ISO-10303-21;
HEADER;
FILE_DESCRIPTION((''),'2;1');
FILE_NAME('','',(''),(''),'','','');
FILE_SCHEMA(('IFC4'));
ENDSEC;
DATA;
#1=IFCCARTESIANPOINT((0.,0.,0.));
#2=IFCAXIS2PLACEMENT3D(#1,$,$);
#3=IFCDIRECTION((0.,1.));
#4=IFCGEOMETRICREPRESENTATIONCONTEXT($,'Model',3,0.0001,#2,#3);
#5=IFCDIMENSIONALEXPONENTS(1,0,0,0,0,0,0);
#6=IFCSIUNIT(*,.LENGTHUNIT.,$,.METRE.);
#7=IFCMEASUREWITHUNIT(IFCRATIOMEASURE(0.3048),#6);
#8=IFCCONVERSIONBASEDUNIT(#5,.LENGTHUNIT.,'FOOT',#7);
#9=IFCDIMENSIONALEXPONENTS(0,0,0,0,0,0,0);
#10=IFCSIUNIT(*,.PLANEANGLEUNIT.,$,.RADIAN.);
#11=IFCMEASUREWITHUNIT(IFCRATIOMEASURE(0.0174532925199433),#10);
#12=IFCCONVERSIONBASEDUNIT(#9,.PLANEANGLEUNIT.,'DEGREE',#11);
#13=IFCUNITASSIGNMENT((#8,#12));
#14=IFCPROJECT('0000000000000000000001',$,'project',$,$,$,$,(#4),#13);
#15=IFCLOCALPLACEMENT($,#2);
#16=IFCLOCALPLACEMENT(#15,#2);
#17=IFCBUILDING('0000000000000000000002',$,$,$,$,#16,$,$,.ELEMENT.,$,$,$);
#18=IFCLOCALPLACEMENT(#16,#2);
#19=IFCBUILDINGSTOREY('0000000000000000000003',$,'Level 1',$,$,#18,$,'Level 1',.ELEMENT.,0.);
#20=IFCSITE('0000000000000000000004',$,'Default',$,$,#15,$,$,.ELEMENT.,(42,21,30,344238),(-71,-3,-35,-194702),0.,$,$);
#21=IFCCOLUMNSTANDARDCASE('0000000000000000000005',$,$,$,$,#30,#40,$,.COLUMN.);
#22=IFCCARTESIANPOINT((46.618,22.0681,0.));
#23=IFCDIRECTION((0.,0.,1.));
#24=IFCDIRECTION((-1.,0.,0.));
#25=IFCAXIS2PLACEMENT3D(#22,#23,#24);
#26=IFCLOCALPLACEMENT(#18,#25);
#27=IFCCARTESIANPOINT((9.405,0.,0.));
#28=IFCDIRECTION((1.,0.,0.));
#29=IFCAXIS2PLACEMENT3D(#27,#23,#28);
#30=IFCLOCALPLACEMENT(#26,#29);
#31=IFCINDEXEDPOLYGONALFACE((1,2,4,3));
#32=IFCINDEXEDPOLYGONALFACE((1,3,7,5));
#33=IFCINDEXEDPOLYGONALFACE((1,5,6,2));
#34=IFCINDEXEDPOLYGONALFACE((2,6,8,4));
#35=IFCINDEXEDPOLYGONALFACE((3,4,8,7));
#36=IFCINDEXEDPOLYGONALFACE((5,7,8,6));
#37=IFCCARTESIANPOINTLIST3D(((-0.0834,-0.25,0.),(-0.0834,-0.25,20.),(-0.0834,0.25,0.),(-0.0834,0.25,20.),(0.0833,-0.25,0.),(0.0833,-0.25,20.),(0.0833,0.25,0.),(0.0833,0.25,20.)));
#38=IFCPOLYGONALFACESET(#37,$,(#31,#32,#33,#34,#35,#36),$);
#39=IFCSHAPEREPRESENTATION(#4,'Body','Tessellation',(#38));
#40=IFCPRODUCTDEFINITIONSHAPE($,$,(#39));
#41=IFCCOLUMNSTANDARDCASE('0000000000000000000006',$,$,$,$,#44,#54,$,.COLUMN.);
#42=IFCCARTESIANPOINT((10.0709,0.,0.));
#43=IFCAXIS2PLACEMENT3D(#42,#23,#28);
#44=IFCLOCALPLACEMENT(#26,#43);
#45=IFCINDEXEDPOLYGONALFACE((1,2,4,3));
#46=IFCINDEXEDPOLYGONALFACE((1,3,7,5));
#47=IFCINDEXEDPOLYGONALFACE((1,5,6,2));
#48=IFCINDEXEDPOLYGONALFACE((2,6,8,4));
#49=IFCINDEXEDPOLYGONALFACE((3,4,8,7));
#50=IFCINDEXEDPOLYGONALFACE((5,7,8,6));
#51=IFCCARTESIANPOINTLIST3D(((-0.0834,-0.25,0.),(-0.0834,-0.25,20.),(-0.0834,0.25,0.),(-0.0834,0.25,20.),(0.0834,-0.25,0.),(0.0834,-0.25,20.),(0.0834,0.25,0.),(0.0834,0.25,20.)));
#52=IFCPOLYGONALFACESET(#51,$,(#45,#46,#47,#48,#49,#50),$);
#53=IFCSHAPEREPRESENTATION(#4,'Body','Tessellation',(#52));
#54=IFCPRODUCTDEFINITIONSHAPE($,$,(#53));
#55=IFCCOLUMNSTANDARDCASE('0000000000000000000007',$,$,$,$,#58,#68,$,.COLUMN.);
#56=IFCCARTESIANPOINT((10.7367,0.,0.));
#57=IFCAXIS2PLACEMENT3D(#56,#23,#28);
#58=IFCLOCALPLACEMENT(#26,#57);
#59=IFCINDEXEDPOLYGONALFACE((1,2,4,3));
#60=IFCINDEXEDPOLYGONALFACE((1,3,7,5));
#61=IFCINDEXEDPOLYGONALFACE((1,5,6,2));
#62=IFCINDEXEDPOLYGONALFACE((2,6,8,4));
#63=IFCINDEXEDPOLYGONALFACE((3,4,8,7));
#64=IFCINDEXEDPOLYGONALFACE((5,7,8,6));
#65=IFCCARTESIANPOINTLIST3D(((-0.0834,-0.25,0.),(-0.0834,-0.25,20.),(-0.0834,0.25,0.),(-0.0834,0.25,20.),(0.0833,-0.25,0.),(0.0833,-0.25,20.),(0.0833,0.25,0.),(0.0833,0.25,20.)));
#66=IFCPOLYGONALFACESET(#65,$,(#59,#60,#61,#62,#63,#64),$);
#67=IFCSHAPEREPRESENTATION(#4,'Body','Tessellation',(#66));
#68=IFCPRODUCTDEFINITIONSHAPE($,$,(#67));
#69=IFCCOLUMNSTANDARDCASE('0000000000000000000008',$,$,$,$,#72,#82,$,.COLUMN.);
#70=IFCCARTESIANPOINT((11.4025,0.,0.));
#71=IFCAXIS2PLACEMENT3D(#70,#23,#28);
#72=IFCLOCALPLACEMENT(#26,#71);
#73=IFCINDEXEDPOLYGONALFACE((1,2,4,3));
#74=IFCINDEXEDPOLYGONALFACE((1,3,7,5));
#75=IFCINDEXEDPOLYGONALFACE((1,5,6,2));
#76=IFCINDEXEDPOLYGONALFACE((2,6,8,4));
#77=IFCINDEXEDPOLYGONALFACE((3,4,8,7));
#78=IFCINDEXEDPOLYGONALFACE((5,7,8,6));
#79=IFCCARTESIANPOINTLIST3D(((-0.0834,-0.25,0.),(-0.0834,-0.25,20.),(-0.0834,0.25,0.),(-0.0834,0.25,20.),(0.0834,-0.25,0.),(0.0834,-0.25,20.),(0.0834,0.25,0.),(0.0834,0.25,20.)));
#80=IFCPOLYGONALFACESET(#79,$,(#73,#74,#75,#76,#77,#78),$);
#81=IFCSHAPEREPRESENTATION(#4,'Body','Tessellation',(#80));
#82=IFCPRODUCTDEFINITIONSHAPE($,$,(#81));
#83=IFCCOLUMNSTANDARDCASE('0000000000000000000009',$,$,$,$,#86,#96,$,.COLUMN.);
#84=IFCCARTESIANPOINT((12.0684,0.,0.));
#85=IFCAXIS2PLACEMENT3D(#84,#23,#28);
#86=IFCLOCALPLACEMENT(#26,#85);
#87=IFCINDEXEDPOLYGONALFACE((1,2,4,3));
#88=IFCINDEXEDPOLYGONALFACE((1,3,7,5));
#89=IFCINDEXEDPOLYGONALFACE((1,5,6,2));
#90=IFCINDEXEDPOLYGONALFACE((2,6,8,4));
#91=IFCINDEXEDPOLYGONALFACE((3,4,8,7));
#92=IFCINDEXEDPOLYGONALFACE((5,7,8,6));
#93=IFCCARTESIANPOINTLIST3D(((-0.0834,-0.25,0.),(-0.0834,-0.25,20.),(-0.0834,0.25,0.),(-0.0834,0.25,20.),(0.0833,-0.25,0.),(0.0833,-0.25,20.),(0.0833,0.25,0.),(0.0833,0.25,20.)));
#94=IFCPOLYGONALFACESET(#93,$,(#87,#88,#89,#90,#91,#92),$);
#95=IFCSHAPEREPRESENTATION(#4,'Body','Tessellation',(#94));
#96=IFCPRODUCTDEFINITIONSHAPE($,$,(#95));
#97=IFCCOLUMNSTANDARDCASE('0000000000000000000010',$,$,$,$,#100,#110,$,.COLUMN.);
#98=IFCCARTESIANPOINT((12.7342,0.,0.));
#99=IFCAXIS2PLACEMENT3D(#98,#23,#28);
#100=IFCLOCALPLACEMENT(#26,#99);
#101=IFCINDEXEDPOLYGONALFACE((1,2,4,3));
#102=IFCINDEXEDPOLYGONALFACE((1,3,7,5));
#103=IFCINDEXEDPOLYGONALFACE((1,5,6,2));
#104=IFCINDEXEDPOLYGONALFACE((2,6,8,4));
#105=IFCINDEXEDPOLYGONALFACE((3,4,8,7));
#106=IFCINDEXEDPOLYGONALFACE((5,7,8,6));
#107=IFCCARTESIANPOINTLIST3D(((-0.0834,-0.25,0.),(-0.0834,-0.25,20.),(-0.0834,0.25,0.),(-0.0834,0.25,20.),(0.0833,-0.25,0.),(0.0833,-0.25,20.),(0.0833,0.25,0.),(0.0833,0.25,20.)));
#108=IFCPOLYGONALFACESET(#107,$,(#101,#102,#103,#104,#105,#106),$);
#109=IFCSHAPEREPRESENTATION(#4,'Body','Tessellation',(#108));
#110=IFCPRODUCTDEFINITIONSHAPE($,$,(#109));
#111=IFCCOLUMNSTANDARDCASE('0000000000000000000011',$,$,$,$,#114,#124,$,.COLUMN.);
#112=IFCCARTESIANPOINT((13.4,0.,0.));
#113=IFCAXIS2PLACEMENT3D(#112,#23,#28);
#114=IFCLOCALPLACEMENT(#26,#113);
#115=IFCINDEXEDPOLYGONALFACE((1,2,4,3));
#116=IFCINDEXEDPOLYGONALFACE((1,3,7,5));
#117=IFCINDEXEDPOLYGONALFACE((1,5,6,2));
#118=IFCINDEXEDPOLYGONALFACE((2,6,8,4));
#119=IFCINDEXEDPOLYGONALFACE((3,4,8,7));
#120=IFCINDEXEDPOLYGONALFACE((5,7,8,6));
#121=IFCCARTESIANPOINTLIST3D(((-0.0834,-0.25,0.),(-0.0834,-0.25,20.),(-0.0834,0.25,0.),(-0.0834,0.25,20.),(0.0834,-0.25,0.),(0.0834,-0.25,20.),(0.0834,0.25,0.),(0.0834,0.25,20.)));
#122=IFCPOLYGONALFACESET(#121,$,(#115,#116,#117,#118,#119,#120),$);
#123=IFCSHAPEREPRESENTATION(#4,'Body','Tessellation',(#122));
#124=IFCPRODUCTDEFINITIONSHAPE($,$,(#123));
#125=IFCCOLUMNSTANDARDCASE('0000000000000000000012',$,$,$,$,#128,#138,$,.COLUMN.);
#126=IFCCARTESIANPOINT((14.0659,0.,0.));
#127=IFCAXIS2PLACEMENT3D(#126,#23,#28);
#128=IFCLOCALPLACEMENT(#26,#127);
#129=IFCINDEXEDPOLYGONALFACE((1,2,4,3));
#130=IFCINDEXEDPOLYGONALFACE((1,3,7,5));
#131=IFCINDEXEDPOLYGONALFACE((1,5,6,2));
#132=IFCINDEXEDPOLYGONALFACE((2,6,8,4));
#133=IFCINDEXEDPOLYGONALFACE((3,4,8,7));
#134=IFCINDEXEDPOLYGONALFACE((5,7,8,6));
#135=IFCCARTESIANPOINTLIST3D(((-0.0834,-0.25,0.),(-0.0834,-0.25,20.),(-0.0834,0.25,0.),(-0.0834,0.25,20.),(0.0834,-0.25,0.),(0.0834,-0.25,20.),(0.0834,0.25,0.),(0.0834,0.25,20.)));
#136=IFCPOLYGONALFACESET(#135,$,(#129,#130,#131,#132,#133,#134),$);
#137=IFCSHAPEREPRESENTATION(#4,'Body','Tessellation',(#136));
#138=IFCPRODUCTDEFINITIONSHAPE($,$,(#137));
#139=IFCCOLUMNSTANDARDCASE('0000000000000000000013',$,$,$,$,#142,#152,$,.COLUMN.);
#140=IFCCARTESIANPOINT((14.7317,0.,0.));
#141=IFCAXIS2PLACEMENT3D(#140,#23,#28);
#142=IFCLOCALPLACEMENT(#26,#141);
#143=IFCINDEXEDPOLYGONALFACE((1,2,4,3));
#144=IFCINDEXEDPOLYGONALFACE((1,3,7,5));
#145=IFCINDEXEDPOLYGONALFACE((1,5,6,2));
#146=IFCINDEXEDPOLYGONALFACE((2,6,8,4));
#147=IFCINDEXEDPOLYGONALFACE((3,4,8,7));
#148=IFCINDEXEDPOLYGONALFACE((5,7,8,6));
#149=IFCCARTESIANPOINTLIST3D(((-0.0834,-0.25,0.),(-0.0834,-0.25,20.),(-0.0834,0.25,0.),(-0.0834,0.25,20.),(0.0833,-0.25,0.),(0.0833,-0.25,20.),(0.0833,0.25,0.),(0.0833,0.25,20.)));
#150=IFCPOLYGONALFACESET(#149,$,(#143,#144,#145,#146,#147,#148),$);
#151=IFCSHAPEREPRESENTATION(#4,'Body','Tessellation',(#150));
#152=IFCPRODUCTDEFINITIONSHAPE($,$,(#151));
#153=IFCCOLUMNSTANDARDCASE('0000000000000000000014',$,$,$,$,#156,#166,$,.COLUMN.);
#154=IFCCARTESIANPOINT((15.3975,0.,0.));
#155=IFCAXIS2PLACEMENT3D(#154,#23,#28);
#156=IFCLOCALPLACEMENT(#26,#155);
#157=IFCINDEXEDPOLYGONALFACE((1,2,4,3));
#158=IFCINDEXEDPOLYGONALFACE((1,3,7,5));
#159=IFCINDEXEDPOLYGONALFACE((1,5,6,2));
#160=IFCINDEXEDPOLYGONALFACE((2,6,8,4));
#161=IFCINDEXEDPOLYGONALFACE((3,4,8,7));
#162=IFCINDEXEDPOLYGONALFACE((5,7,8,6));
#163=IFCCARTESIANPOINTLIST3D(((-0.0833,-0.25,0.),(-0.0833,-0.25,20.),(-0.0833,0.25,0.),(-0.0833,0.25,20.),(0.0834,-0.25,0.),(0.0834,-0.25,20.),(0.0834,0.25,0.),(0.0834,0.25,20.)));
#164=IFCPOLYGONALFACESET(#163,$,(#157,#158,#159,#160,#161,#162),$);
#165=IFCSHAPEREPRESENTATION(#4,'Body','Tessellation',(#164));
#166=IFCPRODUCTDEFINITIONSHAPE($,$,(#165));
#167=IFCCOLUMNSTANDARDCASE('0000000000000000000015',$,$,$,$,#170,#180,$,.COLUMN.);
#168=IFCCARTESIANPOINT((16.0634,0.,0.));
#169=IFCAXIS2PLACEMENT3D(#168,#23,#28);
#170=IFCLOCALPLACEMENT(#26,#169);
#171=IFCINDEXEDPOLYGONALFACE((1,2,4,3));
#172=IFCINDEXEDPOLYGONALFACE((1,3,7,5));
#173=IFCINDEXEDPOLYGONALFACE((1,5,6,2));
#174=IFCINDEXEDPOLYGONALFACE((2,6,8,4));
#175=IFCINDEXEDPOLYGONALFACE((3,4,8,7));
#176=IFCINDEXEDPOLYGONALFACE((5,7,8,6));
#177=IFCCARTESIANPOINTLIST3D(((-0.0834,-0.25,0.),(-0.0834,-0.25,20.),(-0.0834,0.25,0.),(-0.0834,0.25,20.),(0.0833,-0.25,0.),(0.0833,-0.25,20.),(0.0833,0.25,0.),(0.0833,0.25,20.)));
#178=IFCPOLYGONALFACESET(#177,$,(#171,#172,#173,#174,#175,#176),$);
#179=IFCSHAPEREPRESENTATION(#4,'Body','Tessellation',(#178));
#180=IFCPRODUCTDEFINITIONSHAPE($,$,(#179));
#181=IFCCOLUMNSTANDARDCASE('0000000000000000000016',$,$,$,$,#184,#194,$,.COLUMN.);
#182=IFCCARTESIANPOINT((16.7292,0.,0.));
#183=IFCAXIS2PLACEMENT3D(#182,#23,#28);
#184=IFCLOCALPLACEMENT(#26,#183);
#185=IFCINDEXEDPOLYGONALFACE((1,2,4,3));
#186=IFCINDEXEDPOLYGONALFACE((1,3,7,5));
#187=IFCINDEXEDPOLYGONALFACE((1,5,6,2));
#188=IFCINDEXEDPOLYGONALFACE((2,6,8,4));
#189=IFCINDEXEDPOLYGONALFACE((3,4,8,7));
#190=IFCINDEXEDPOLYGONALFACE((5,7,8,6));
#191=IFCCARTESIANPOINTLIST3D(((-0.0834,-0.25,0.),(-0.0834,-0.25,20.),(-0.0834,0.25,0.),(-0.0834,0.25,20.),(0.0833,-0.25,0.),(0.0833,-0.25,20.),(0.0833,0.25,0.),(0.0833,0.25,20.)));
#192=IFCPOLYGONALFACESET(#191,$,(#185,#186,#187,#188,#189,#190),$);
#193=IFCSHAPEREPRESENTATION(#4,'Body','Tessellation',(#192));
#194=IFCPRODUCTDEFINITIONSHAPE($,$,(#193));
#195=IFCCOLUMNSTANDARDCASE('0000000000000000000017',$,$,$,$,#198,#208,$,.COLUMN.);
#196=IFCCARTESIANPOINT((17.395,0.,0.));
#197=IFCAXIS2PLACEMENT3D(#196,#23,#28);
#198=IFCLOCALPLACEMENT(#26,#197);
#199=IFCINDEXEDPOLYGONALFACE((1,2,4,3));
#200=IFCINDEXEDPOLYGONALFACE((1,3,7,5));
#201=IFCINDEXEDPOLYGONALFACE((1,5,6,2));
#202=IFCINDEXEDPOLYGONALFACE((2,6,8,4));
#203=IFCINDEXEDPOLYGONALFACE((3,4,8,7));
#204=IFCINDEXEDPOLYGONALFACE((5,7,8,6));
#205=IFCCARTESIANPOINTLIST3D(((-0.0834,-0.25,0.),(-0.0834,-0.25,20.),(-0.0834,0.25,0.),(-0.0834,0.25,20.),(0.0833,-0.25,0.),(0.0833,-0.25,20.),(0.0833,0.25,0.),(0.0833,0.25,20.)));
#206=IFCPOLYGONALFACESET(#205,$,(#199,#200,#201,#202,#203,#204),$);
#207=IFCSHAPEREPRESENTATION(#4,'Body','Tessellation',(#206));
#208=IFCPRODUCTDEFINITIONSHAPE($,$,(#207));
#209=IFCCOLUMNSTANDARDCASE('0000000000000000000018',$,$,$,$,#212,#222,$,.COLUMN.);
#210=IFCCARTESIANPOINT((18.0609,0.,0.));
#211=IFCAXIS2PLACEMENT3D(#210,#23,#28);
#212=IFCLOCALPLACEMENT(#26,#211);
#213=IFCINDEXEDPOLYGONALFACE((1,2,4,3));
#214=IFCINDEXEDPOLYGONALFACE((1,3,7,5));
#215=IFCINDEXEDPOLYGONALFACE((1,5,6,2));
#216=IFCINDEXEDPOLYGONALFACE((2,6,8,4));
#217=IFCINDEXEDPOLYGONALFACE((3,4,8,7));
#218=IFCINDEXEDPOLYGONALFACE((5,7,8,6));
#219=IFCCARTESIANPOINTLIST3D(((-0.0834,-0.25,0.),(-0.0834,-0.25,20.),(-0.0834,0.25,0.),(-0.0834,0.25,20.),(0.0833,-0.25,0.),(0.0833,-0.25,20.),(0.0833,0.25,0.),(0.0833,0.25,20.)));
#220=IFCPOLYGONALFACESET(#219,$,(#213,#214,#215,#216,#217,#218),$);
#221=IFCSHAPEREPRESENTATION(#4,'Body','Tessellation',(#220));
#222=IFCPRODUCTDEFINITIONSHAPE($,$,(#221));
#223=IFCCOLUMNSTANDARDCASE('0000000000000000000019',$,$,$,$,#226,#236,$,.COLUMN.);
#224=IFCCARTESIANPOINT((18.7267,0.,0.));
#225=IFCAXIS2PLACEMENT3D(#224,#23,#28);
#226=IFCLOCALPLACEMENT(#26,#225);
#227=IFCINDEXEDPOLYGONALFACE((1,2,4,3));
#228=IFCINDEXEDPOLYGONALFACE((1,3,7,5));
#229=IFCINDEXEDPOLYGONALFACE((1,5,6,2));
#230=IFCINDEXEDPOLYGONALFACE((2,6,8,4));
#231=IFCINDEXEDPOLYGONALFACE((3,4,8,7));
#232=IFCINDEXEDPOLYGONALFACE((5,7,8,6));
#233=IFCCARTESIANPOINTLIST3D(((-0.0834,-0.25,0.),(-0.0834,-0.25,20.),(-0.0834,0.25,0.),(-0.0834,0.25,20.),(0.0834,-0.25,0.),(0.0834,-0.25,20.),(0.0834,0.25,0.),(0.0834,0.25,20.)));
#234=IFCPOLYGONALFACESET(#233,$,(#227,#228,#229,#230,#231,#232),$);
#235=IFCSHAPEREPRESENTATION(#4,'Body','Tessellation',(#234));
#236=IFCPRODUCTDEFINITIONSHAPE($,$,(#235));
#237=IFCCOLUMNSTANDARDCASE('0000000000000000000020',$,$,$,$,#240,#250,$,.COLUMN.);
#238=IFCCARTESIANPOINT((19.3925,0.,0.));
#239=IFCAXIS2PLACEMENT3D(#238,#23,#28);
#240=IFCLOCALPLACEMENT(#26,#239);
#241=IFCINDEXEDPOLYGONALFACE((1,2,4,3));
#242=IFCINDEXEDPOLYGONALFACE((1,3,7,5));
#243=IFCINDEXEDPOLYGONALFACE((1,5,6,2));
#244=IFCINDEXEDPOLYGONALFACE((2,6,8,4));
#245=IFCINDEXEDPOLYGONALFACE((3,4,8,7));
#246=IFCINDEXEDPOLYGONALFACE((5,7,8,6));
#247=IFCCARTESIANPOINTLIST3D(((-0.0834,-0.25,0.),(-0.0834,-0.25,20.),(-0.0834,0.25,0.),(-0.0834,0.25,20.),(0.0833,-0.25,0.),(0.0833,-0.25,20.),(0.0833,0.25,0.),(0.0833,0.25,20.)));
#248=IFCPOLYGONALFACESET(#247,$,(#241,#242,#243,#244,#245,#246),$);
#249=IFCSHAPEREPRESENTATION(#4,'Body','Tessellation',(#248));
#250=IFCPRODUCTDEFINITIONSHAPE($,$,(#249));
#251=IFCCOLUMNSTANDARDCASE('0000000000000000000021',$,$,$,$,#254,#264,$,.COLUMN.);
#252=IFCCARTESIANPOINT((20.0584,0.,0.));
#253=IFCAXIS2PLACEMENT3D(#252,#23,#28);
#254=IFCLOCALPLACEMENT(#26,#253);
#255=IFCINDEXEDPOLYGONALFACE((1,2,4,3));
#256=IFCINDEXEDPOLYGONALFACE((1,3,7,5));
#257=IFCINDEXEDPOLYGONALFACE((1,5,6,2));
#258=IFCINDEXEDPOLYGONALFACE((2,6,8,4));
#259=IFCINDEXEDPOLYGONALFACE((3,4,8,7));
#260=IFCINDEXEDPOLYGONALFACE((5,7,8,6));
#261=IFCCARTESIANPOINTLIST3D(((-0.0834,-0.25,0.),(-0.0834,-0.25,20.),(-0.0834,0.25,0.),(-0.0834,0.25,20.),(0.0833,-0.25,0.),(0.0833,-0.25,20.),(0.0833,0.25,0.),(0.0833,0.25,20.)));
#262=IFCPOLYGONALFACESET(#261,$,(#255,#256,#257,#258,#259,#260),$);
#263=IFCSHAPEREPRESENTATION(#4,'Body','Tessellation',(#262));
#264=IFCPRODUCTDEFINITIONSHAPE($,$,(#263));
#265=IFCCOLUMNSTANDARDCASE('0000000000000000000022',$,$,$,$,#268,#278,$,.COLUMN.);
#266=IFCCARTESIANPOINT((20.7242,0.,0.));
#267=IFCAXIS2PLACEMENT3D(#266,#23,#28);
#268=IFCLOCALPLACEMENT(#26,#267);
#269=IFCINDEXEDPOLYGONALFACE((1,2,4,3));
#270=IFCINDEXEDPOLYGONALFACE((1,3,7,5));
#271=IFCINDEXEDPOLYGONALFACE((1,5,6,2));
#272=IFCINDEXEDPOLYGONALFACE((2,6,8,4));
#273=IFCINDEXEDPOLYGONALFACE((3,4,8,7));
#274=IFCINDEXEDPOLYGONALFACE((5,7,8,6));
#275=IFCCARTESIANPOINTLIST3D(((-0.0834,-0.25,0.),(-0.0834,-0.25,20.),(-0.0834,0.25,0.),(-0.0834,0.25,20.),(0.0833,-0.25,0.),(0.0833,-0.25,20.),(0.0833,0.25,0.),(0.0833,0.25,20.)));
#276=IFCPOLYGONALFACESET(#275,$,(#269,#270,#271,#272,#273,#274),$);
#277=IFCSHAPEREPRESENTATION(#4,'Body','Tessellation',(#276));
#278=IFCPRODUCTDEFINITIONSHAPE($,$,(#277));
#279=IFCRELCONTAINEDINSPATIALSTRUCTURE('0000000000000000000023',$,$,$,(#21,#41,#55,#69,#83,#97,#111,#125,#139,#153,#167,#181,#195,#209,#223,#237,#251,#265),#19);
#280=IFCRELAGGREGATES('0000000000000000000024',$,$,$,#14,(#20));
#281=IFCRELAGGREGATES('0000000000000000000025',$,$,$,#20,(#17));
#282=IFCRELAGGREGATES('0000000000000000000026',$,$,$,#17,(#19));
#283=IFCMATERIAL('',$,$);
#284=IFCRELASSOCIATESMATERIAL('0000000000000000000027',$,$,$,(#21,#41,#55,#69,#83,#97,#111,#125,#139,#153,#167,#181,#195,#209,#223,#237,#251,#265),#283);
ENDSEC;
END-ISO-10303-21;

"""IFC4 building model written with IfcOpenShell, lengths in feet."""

from ifc_helpers import new_model, entity, si_unit, converted_unit, direction, frame, origin, place, context, project, spatial, rectangle, extrude, material, element, save


model = new_model("IFC4")

# Units and contexts
model_context = context("Model", 3, precision=0.0001, world=origin(), true_north=direction((0.0, 1.0)))
ifc_project = project(units=[converted_unit("LENGTHUNIT", "FOOT", entity("IfcRatioMeasure", 0.3048), si_unit("LENGTHUNIT", "METRE"), dimensions=[1, 0, 0, 0, 0, 0, 0]), converted_unit("PLANEANGLEUNIT", "DEGREE", entity("IfcRatioMeasure", 0.0174532925199433), si_unit("PLANEANGLEUNIT", "RADIAN"), dimensions=[0, 0, 0, 0, 0, 0, 0])], contexts=[model_context])

# Site, building, storey
site_placement = place(None, origin())
site = spatial("IfcSite", under=ifc_project, at=site_placement, Name="Default", CompositionType="ELEMENT", RefLatitude=(42, 21, 30, 344238), RefLongitude=(-71, -3, -35, -194702), RefElevation=0.0)
building_placement = place(site_placement, origin())
building = spatial("IfcBuilding", under=site, at=building_placement, CompositionType="ELEMENT")
storey_placement = place(building_placement, origin())
storey = spatial("IfcBuildingStorey", under=building, at=storey_placement, Name="Level 1", LongName="Level 1", CompositionType="ELEMENT", Elevation=0.0)

# Columns
ifc_material = material(Name="")
placement = place(storey_placement, frame((46.618, 22.0681, 0.0), z_axis=(0.0, 0.0, 1.0), x_axis=(-1.0, 0.0, 0.0)))
for number, where, z_axis, x_axis in (
    (1, (9.405, 0.0, 0.0), (0.0, 0.0, 1.0), (1.0, 0.0, 0.0)),
    (2, (10.0709, 0.0, 0.0), (0.0, 0.0, 1.0), (1.0, 0.0, 0.0)),
    (3, (10.7367, 0.0, 0.0), (0.0, 0.0, 1.0), (1.0, 0.0, 0.0)),
    (4, (11.4025, 0.0, 0.0), (0.0, 0.0, 1.0), (1.0, 0.0, 0.0)),
    (5, (12.0684, 0.0, 0.0), (0.0, 0.0, 1.0), (1.0, 0.0, 0.0)),
    (6, (12.7342, 0.0, 0.0), (0.0, 0.0, 1.0), (1.0, 0.0, 0.0)),
    (7, (13.4, 0.0, 0.0), (0.0, 0.0, 1.0), (1.0, 0.0, 0.0)),
    (8, (14.0659, 0.0, 0.0), (0.0, 0.0, 1.0), (1.0, 0.0, 0.0)),
    (9, (14.7317, 0.0, 0.0), (0.0, 0.0, 1.0), (1.0, 0.0, 0.0)),
    (10, (15.3975, 0.0, 0.0), (0.0, 0.0, 1.0), (1.0, 0.0, 0.0)),
    (11, (16.0634, 0.0, 0.0), (0.0, 0.0, 1.0), (1.0, 0.0, 0.0)),
    (12, (16.7292, 0.0, 0.0), (0.0, 0.0, 1.0), (1.0, 0.0, 0.0)),
    (13, (17.395, 0.0, 0.0), (0.0, 0.0, 1.0), (1.0, 0.0, 0.0)),
    (14, (18.0609, 0.0, 0.0), (0.0, 0.0, 1.0), (1.0, 0.0, 0.0)),
    (15, (18.7267, 0.0, 0.0), (0.0, 0.0, 1.0), (1.0, 0.0, 0.0)),
    (16, (19.3925, 0.0, 0.0), (0.0, 0.0, 1.0), (1.0, 0.0, 0.0)),
    (17, (20.0584, 0.0, 0.0), (0.0, 0.0, 1.0), (1.0, 0.0, 0.0)),
    (18, (20.7242, 0.0, 0.0), (0.0, 0.0, 1.0), (1.0, 0.0, 0.0)),
):
    element("IfcColumnStandardCase", number, at=place(placement, frame(where, z_axis=z_axis, x_axis=x_axis)), inside=storey, material=ifc_material, PredefinedType="COLUMN", context=model_context, shape_type="SweptSolid", body=[
        extrude(rectangle(XDim=0.1667, YDim=0.5), origin(), (0.0, 0.0, 1.0), 20.0),
    ])

save(model, "model.ifc")
